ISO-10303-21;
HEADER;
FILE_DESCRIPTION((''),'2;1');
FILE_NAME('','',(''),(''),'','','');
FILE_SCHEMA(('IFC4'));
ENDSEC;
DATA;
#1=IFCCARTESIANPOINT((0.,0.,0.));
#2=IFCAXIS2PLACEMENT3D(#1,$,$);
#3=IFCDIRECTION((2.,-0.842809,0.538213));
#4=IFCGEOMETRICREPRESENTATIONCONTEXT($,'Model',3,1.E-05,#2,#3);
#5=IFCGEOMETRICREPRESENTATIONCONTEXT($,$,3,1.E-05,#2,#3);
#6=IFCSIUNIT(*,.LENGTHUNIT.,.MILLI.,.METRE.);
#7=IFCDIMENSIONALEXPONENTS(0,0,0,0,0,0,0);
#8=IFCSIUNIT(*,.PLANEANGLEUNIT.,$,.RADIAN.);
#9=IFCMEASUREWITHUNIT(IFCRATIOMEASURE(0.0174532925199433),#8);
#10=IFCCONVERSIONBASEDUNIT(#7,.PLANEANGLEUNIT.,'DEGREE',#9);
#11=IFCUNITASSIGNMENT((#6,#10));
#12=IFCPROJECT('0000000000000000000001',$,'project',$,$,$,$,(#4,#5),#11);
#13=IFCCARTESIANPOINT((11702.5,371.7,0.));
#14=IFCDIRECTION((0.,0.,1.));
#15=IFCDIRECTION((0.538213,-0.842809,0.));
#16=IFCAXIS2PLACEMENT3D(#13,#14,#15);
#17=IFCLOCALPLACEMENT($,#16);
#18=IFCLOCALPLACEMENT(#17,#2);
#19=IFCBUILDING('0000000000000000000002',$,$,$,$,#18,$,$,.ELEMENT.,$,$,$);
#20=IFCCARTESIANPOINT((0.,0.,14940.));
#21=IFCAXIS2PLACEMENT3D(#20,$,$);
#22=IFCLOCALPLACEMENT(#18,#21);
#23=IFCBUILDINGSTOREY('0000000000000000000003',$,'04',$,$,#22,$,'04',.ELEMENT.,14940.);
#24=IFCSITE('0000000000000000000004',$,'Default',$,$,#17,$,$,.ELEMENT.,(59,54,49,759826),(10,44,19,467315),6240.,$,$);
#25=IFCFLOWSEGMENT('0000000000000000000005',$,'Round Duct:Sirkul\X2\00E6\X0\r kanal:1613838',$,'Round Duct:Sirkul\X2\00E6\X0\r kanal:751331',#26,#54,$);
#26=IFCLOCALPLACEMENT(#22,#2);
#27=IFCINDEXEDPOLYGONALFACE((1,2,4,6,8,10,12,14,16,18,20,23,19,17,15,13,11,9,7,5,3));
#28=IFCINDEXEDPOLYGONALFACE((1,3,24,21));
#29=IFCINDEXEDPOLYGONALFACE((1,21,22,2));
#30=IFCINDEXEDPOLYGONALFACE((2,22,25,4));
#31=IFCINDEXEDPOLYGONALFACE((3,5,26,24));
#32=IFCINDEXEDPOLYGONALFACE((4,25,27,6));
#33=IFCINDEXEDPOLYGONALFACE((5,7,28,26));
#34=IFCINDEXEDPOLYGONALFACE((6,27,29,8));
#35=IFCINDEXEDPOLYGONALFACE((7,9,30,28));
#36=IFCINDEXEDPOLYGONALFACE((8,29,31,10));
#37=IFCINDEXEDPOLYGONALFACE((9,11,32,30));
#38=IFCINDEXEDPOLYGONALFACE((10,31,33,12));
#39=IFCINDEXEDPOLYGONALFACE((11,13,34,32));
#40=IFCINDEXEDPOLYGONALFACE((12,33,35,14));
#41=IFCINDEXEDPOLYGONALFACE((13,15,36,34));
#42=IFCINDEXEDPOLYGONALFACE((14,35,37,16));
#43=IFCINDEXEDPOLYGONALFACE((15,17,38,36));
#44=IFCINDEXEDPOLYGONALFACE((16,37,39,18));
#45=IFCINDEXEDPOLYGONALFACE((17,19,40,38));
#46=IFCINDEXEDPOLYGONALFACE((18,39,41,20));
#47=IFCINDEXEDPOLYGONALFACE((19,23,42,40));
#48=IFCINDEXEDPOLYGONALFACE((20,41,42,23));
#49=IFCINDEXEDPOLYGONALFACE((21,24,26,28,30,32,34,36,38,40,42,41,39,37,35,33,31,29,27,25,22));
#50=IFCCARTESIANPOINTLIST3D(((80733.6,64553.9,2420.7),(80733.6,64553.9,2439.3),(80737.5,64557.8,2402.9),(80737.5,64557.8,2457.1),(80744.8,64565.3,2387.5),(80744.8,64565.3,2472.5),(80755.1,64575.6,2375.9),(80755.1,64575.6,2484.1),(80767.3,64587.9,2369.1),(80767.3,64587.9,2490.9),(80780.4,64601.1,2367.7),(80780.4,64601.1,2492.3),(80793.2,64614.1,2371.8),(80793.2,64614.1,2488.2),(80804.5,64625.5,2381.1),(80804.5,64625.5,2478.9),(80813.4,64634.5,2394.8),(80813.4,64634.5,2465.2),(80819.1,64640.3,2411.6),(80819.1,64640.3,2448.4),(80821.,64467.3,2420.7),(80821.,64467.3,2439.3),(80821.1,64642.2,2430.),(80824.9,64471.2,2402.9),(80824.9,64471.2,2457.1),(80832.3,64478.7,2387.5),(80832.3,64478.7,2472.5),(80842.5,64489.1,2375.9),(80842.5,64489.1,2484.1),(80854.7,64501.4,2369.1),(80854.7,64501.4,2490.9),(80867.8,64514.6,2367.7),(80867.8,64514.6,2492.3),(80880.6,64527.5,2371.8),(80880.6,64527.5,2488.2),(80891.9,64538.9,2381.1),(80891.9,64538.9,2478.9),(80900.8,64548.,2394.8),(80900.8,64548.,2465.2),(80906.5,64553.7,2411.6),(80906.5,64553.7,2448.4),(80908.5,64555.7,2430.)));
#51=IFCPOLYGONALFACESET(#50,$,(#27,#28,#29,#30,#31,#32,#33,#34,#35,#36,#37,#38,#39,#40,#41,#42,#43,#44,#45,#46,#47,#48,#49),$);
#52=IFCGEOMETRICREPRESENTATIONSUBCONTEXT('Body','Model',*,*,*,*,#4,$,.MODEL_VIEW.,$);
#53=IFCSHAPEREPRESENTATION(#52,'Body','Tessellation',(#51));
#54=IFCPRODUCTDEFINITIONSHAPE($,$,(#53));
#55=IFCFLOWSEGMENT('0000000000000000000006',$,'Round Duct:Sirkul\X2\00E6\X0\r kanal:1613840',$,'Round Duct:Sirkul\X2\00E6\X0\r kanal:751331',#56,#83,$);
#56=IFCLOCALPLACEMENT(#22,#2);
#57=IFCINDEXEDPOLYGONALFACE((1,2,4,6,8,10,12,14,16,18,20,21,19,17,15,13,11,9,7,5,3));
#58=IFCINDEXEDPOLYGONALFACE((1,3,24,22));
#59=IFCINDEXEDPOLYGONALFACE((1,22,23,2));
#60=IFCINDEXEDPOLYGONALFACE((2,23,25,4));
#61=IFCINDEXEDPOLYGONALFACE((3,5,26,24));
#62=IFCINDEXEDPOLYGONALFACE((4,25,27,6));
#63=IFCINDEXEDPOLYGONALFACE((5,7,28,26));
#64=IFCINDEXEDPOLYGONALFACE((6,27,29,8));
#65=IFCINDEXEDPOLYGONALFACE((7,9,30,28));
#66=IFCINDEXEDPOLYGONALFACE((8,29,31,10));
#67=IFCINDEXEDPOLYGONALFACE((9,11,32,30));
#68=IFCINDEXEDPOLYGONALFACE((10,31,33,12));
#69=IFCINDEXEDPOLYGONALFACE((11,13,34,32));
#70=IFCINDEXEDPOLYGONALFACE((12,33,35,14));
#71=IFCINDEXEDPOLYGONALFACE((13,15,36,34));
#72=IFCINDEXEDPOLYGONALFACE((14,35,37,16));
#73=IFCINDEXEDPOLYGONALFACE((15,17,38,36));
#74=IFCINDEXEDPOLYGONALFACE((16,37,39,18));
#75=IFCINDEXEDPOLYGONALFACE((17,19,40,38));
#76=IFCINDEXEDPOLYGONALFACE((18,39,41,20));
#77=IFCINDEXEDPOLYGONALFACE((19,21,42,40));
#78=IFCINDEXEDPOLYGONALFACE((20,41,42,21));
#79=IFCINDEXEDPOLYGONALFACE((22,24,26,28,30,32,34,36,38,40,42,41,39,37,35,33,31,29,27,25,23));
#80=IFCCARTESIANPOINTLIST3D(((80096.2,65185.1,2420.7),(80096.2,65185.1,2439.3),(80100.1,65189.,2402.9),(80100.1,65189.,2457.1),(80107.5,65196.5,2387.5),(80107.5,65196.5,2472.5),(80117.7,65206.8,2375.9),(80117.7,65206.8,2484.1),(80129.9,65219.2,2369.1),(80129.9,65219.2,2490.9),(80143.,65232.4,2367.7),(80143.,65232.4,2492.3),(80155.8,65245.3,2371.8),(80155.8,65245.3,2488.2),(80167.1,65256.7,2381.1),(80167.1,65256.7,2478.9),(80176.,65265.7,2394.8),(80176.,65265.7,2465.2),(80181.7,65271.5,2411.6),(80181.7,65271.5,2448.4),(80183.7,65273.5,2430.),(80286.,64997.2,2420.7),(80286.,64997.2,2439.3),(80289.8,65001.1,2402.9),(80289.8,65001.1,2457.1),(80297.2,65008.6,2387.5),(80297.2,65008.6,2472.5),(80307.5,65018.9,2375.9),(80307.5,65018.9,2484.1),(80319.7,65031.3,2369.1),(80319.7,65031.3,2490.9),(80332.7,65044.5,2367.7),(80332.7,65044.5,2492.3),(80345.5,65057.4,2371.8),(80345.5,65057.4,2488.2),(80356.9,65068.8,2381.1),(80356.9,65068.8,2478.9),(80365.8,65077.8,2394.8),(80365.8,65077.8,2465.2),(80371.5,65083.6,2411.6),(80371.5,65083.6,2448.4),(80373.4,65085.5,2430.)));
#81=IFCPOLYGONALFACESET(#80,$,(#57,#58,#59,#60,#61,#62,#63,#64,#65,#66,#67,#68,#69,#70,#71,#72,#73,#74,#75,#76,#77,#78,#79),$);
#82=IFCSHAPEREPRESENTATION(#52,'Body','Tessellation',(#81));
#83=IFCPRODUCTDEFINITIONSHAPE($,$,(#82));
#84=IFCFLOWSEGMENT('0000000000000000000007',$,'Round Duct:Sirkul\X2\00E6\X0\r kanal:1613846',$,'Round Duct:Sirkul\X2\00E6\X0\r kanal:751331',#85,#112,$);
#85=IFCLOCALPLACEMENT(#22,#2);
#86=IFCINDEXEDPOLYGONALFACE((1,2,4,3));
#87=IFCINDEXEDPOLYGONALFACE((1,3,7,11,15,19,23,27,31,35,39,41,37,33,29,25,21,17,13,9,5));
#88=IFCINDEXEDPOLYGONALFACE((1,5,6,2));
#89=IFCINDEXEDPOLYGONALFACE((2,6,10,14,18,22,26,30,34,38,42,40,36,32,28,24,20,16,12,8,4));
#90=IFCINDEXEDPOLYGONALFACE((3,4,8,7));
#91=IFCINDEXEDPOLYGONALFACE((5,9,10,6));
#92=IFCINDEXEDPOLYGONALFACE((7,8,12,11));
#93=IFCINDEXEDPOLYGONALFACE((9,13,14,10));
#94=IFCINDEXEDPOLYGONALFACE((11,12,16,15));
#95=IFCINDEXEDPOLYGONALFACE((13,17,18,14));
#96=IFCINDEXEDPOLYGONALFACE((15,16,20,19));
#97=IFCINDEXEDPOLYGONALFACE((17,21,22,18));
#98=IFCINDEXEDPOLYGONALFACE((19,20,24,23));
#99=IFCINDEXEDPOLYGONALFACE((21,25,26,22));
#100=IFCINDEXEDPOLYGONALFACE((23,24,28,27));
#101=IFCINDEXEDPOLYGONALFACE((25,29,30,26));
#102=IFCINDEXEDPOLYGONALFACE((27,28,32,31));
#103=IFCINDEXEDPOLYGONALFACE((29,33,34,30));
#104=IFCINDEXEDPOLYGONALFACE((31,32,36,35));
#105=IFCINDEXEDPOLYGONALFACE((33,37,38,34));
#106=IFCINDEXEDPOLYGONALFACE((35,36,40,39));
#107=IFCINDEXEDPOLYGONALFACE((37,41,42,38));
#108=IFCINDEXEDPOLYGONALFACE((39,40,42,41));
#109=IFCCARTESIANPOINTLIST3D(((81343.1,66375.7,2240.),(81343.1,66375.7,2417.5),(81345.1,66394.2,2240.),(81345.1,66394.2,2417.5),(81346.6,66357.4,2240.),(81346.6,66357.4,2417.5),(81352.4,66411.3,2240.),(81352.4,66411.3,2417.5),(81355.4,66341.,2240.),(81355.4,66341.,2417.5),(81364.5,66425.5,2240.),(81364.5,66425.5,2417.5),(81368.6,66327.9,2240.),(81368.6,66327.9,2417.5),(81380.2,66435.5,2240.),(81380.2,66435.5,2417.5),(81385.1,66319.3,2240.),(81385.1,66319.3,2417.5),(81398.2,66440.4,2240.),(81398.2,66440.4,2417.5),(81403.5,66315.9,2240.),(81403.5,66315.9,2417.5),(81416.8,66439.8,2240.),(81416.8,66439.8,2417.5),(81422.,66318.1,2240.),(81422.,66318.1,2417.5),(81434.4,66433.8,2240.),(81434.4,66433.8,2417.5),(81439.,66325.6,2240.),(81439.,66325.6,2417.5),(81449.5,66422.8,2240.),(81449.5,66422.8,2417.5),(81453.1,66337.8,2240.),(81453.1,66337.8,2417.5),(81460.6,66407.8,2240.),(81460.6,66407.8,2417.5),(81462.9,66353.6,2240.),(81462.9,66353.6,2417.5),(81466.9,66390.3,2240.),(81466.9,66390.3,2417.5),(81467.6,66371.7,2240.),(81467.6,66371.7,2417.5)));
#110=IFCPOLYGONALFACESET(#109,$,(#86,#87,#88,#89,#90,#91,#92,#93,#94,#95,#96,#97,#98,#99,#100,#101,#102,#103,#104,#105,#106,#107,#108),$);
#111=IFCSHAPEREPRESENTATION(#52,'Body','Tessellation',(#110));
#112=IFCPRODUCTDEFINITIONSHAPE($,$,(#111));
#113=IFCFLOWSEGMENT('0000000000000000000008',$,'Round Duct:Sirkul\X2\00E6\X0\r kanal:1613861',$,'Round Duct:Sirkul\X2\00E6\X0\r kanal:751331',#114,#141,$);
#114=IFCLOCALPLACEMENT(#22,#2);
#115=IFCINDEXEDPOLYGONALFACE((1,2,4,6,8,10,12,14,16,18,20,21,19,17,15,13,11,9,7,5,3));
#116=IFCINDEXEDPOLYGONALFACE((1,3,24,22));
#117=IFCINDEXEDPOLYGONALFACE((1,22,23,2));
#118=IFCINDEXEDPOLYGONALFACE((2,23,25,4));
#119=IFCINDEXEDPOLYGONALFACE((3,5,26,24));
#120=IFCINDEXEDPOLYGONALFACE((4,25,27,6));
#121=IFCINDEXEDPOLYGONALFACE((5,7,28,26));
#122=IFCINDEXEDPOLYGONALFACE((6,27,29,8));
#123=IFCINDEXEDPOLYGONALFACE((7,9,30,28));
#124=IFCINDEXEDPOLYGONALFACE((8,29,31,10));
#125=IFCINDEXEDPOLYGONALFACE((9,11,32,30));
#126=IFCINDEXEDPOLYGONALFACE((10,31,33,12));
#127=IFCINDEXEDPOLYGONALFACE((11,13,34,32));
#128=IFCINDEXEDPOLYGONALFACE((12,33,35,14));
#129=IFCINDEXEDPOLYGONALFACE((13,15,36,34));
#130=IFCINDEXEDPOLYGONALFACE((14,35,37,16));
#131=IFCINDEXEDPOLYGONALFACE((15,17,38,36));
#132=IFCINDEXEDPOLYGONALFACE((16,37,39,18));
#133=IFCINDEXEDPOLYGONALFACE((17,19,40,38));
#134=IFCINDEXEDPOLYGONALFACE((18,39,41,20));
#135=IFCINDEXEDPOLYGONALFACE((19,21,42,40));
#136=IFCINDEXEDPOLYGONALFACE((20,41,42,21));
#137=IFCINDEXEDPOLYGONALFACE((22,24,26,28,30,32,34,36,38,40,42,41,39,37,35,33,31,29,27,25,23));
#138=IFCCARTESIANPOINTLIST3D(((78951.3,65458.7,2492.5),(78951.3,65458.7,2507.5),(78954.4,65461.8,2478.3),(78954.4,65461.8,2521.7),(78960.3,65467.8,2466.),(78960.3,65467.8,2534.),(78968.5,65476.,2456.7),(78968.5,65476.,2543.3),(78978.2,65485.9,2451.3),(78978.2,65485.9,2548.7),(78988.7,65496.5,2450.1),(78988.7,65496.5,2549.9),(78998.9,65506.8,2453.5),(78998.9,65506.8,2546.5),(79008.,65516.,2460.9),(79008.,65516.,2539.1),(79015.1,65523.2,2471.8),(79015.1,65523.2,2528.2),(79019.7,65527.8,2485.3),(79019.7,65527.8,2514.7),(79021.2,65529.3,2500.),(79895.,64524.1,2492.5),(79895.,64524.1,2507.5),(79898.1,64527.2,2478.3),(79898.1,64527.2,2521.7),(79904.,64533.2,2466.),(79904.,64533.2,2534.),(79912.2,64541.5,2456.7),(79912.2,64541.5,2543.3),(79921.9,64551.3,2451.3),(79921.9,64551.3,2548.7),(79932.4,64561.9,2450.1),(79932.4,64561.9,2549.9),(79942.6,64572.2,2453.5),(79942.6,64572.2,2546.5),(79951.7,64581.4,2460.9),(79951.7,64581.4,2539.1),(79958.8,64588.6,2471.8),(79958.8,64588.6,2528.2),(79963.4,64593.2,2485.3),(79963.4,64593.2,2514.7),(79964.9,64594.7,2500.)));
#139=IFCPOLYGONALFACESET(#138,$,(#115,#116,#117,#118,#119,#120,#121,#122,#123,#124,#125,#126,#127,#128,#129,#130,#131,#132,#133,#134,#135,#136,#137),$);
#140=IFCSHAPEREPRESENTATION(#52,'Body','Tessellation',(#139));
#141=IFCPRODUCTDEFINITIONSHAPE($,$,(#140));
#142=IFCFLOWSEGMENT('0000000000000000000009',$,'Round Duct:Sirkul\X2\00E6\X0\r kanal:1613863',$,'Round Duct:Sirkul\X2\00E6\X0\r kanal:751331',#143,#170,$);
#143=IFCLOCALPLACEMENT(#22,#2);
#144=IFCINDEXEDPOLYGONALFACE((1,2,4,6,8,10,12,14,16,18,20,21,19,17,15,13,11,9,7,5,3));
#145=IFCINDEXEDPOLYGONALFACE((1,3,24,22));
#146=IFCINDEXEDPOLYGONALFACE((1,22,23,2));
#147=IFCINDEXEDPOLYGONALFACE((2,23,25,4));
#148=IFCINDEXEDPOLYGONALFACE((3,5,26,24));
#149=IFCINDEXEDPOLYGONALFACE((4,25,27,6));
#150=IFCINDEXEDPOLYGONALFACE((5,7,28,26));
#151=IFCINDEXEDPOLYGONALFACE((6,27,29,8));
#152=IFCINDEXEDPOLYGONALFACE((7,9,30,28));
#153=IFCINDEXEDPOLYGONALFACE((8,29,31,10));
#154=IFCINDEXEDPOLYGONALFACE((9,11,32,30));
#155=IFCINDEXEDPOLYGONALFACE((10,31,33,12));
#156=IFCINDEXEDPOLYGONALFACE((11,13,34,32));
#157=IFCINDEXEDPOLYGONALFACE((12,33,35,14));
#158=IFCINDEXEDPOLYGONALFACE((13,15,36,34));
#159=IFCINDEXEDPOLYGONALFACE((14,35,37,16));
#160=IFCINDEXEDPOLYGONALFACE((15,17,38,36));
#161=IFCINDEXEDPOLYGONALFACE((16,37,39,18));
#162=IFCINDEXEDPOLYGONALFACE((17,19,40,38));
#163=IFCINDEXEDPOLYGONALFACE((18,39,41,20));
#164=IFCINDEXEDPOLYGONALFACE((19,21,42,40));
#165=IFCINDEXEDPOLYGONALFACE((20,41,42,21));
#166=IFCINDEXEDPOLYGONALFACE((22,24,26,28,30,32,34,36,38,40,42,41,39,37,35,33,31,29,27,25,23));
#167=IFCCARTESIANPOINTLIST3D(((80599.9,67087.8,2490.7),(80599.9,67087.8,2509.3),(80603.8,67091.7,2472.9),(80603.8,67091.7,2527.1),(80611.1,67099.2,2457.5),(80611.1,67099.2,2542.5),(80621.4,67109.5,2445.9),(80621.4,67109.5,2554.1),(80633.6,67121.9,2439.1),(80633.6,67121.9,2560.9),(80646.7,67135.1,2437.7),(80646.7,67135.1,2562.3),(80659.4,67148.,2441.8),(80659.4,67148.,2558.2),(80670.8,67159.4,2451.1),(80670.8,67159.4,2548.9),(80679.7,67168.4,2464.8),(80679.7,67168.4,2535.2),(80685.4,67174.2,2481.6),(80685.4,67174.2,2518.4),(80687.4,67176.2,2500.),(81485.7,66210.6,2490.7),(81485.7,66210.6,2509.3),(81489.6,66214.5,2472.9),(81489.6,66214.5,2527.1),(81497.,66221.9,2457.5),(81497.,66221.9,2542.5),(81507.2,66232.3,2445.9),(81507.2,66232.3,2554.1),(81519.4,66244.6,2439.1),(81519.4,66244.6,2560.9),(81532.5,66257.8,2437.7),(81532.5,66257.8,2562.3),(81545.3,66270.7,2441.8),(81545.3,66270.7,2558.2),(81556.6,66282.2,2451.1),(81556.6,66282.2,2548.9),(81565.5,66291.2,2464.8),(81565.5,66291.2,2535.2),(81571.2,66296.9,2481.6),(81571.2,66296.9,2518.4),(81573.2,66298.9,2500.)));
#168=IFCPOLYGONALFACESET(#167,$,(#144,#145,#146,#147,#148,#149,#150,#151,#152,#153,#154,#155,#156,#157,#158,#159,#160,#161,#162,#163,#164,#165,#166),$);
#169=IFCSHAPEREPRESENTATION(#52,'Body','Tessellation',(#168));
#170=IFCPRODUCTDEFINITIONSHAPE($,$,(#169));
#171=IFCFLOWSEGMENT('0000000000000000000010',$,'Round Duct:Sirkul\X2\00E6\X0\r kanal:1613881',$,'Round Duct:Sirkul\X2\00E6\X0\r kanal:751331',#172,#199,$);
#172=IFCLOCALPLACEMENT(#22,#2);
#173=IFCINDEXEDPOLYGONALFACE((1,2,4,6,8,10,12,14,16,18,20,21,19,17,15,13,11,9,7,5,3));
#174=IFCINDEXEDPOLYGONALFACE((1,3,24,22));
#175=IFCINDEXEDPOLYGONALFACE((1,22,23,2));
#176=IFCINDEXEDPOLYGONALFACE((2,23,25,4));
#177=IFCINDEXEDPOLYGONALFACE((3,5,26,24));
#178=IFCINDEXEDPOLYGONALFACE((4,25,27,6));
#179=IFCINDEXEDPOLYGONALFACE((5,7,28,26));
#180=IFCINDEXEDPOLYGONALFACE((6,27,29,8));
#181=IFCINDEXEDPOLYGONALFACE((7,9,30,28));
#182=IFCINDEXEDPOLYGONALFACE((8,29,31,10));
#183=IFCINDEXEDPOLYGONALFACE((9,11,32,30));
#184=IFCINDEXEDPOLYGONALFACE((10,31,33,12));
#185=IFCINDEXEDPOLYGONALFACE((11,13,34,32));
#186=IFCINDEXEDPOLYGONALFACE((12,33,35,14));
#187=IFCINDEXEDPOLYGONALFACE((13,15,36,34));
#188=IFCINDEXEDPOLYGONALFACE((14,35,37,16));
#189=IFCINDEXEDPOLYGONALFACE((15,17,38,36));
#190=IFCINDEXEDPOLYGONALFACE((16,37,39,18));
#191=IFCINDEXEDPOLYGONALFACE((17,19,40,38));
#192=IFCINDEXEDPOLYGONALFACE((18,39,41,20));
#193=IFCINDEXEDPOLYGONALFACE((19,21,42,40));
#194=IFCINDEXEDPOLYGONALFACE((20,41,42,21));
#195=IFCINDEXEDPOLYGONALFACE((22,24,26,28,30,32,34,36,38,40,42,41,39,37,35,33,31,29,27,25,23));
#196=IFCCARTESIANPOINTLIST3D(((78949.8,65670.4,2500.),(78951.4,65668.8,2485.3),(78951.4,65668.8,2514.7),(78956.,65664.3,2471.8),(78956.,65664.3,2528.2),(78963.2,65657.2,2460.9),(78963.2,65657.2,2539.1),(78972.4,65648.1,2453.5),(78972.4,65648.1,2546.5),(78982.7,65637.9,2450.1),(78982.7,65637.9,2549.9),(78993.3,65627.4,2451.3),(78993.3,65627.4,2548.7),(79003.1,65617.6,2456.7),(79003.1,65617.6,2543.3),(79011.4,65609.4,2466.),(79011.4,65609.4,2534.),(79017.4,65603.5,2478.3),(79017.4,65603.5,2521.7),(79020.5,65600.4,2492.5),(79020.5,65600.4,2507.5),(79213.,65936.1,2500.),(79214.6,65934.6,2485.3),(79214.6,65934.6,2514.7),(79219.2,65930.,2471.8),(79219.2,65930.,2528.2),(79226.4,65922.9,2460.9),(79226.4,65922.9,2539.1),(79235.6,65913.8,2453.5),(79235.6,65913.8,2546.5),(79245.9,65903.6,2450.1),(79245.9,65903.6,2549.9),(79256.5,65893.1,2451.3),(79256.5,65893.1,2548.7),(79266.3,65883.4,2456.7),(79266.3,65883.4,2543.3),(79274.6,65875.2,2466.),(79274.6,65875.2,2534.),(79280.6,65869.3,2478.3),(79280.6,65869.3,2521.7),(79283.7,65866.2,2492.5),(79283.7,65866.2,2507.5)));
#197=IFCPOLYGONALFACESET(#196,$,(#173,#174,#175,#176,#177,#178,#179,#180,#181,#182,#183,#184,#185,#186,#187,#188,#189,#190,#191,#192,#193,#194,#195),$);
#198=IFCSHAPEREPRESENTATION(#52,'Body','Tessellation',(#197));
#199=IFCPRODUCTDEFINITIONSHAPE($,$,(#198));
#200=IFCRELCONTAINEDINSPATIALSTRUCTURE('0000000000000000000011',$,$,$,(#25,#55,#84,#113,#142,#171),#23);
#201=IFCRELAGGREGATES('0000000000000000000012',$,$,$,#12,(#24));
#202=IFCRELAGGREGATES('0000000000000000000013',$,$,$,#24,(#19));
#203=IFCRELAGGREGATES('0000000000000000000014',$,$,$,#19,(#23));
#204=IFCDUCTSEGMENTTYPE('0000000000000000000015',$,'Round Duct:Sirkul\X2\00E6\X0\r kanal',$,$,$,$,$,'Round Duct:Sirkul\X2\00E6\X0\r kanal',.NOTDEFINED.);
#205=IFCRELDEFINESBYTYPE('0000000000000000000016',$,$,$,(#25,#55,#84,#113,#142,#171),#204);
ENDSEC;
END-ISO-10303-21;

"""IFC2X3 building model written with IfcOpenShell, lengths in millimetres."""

from ifc_helpers import new_model, entity, si_unit, converted_unit, direction, frame, frame_2d, origin, origin_2d_with_axis, place, context, subcontext, project, spatial, circle, extrude, type_object, element, save


model = new_model("IFC2X3")

# Units and contexts
model_context = context("Model", 3, precision=1e-05, world=origin(), true_north=direction((2.0, -0.842809, 0.538213)))
context_of_model = context(None, 3, precision=1e-05, world=origin(), true_north=direction((2.0, -0.842809, 0.538213)))
body_context = subcontext(model_context, "Body", "Model", "MODEL_VIEW")
ifc_project = project(units=[si_unit("LENGTHUNIT", "METRE", prefix="MILLI"), converted_unit("PLANEANGLEUNIT", "DEGREE", entity("IfcRatioMeasure", 0.0174532925199433), si_unit("PLANEANGLEUNIT", "RADIAN"), dimensions=[0, 0, 0, 0, 0, 0, 0])], contexts=[model_context, context_of_model])

# Site, building, storey
site_placement = place(None, frame((11702.5, 371.7, 0.0), z_axis=(0.0, 0.0, 1.0), x_axis=(0.538213, -0.842809, 0.0)))
site = spatial("IfcSite", under=ifc_project, at=site_placement, Name="Default", CompositionType="ELEMENT", RefLatitude=(59, 54, 49, 759826), RefLongitude=(10, 44, 19, 467315), RefElevation=6240.0)
building_placement = place(site_placement, origin())
building = spatial("IfcBuilding", under=site, at=building_placement, CompositionType="ELEMENT")
storey_placement = place(building_placement, frame((0.0, 0.0, 14940.0)))
storey = spatial("IfcBuildingStorey", under=building, at=storey_placement, Name="04", LongName="04", CompositionType="ELEMENT", Elevation=14940.0)

# Flow segments
duct_segment_type = type_object("IfcDuctSegmentType", Name="Round Duct:Sirkulær kanal", ElementType="Round Duct:Sirkulær kanal", PredefinedType="NOTDEFINED")
flow_segment_1_placement = place(storey_placement, origin())
element("IfcFlowSegment", 1, at=flow_segment_1_placement, inside=storey, type_object=duct_segment_type, Name="Round Duct:Sirkulær kanal:1613838", ObjectType="Round Duct:Sirkulær kanal:751331", context=body_context, shape_type="SweptSolid", body=[
    extrude(circle(Radius=62.5, at=origin_2d_with_axis()), frame((80864.5, 64511.3, 2430.0), z_axis=(-0.710528, 0.703669, 0.0), x_axis=(0.703669, 0.710528, 0.0)), (0.0, 0.0, 1.0), 123.0),
])
flow_segment_2_placement = place(storey_placement, origin())
element("IfcFlowSegment", 2, at=flow_segment_2_placement, inside=storey, type_object=duct_segment_type, Name="Round Duct:Sirkulær kanal:1613840", ObjectType="Round Duct:Sirkulær kanal:751331", context=body_context, shape_type="SweptSolid", body=[
    extrude(circle(Radius=62.5, at=frame_2d((0.0, 0.0), x_axis=(1.0, 0.0))), frame((80139.7, 65229.0, 2430.0), z_axis=(0.710528, -0.703669, 0.0), x_axis=(0.703669, 0.710528, 0.0)), (0.0, 0.0, 1.0), 267.0),
])
flow_segment_3_placement = place(storey_placement, origin())
element("IfcFlowSegment", 3, at=flow_segment_3_placement, inside=storey, type_object=duct_segment_type, Name="Round Duct:Sirkulær kanal:1613846", ObjectType="Round Duct:Sirkulær kanal:751331", context=body_context, shape_type="SweptSolid", body=[
    extrude(circle(Radius=62.5, at=frame_2d((0.0, 0.0), x_axis=(1.0, 0.0))), frame((81405.5, 66378.4, 2240.0), z_axis=(0.0, 0.0, 1.0), x_axis=(0.703669, 0.710528, 0.0)), (0.0, 0.0, 1.0), 177.5),
])
flow_segment_4_placement = place(storey_placement, origin())
element("IfcFlowSegment", 4, at=flow_segment_4_placement, inside=storey, type_object=duct_segment_type, Name="Round Duct:Sirkulær kanal:1613861", ObjectType="Round Duct:Sirkulær kanal:751331", context=body_context, shape_type="SweptSolid", body=[
    extrude(circle(Radius=50.0, at=origin_2d_with_axis()), frame((78986.1, 65493.8, 2500.0), z_axis=(0.710528, -0.703669, 0.0), x_axis=(0.703669, 0.710528, 0.0)), (0.0, 0.0, 1.0), 1328.2),
])
flow_segment_5_placement = place(storey_placement, origin())
element("IfcFlowSegment", 5, at=flow_segment_5_placement, inside=storey, type_object=duct_segment_type, Name="Round Duct:Sirkulær kanal:1613863", ObjectType="Round Duct:Sirkulær kanal:751331", context=body_context, shape_type="SweptSolid", body=[
    extrude(circle(Radius=62.5, at=origin_2d_with_axis()), frame((80643.4, 67131.8, 2500.0), z_axis=(0.710528, -0.703669, 0.0), x_axis=(0.703669, 0.710528, 0.0)), (0.0, 0.0, 1.0), 1246.7),
])
flow_segment_6_placement = place(storey_placement, origin())
element("IfcFlowSegment", 6, at=flow_segment_6_placement, inside=storey, type_object=duct_segment_type, Name="Round Duct:Sirkulær kanal:1613881", ObjectType="Round Duct:Sirkulær kanal:751331", context=body_context, shape_type="SweptSolid", body=[
    extrude(circle(Radius=50.0, at=frame_2d((0.0, 0.0), x_axis=(1.0, 0.0))), frame((78985.4, 65635.2, 2500.0), z_axis=(0.703669, 0.710528, 0.0), x_axis=(-0.710528, 0.703669, 0.0)), (0.0, 0.0, 1.0), 374.0),
])

save(model, "model.ifc")
